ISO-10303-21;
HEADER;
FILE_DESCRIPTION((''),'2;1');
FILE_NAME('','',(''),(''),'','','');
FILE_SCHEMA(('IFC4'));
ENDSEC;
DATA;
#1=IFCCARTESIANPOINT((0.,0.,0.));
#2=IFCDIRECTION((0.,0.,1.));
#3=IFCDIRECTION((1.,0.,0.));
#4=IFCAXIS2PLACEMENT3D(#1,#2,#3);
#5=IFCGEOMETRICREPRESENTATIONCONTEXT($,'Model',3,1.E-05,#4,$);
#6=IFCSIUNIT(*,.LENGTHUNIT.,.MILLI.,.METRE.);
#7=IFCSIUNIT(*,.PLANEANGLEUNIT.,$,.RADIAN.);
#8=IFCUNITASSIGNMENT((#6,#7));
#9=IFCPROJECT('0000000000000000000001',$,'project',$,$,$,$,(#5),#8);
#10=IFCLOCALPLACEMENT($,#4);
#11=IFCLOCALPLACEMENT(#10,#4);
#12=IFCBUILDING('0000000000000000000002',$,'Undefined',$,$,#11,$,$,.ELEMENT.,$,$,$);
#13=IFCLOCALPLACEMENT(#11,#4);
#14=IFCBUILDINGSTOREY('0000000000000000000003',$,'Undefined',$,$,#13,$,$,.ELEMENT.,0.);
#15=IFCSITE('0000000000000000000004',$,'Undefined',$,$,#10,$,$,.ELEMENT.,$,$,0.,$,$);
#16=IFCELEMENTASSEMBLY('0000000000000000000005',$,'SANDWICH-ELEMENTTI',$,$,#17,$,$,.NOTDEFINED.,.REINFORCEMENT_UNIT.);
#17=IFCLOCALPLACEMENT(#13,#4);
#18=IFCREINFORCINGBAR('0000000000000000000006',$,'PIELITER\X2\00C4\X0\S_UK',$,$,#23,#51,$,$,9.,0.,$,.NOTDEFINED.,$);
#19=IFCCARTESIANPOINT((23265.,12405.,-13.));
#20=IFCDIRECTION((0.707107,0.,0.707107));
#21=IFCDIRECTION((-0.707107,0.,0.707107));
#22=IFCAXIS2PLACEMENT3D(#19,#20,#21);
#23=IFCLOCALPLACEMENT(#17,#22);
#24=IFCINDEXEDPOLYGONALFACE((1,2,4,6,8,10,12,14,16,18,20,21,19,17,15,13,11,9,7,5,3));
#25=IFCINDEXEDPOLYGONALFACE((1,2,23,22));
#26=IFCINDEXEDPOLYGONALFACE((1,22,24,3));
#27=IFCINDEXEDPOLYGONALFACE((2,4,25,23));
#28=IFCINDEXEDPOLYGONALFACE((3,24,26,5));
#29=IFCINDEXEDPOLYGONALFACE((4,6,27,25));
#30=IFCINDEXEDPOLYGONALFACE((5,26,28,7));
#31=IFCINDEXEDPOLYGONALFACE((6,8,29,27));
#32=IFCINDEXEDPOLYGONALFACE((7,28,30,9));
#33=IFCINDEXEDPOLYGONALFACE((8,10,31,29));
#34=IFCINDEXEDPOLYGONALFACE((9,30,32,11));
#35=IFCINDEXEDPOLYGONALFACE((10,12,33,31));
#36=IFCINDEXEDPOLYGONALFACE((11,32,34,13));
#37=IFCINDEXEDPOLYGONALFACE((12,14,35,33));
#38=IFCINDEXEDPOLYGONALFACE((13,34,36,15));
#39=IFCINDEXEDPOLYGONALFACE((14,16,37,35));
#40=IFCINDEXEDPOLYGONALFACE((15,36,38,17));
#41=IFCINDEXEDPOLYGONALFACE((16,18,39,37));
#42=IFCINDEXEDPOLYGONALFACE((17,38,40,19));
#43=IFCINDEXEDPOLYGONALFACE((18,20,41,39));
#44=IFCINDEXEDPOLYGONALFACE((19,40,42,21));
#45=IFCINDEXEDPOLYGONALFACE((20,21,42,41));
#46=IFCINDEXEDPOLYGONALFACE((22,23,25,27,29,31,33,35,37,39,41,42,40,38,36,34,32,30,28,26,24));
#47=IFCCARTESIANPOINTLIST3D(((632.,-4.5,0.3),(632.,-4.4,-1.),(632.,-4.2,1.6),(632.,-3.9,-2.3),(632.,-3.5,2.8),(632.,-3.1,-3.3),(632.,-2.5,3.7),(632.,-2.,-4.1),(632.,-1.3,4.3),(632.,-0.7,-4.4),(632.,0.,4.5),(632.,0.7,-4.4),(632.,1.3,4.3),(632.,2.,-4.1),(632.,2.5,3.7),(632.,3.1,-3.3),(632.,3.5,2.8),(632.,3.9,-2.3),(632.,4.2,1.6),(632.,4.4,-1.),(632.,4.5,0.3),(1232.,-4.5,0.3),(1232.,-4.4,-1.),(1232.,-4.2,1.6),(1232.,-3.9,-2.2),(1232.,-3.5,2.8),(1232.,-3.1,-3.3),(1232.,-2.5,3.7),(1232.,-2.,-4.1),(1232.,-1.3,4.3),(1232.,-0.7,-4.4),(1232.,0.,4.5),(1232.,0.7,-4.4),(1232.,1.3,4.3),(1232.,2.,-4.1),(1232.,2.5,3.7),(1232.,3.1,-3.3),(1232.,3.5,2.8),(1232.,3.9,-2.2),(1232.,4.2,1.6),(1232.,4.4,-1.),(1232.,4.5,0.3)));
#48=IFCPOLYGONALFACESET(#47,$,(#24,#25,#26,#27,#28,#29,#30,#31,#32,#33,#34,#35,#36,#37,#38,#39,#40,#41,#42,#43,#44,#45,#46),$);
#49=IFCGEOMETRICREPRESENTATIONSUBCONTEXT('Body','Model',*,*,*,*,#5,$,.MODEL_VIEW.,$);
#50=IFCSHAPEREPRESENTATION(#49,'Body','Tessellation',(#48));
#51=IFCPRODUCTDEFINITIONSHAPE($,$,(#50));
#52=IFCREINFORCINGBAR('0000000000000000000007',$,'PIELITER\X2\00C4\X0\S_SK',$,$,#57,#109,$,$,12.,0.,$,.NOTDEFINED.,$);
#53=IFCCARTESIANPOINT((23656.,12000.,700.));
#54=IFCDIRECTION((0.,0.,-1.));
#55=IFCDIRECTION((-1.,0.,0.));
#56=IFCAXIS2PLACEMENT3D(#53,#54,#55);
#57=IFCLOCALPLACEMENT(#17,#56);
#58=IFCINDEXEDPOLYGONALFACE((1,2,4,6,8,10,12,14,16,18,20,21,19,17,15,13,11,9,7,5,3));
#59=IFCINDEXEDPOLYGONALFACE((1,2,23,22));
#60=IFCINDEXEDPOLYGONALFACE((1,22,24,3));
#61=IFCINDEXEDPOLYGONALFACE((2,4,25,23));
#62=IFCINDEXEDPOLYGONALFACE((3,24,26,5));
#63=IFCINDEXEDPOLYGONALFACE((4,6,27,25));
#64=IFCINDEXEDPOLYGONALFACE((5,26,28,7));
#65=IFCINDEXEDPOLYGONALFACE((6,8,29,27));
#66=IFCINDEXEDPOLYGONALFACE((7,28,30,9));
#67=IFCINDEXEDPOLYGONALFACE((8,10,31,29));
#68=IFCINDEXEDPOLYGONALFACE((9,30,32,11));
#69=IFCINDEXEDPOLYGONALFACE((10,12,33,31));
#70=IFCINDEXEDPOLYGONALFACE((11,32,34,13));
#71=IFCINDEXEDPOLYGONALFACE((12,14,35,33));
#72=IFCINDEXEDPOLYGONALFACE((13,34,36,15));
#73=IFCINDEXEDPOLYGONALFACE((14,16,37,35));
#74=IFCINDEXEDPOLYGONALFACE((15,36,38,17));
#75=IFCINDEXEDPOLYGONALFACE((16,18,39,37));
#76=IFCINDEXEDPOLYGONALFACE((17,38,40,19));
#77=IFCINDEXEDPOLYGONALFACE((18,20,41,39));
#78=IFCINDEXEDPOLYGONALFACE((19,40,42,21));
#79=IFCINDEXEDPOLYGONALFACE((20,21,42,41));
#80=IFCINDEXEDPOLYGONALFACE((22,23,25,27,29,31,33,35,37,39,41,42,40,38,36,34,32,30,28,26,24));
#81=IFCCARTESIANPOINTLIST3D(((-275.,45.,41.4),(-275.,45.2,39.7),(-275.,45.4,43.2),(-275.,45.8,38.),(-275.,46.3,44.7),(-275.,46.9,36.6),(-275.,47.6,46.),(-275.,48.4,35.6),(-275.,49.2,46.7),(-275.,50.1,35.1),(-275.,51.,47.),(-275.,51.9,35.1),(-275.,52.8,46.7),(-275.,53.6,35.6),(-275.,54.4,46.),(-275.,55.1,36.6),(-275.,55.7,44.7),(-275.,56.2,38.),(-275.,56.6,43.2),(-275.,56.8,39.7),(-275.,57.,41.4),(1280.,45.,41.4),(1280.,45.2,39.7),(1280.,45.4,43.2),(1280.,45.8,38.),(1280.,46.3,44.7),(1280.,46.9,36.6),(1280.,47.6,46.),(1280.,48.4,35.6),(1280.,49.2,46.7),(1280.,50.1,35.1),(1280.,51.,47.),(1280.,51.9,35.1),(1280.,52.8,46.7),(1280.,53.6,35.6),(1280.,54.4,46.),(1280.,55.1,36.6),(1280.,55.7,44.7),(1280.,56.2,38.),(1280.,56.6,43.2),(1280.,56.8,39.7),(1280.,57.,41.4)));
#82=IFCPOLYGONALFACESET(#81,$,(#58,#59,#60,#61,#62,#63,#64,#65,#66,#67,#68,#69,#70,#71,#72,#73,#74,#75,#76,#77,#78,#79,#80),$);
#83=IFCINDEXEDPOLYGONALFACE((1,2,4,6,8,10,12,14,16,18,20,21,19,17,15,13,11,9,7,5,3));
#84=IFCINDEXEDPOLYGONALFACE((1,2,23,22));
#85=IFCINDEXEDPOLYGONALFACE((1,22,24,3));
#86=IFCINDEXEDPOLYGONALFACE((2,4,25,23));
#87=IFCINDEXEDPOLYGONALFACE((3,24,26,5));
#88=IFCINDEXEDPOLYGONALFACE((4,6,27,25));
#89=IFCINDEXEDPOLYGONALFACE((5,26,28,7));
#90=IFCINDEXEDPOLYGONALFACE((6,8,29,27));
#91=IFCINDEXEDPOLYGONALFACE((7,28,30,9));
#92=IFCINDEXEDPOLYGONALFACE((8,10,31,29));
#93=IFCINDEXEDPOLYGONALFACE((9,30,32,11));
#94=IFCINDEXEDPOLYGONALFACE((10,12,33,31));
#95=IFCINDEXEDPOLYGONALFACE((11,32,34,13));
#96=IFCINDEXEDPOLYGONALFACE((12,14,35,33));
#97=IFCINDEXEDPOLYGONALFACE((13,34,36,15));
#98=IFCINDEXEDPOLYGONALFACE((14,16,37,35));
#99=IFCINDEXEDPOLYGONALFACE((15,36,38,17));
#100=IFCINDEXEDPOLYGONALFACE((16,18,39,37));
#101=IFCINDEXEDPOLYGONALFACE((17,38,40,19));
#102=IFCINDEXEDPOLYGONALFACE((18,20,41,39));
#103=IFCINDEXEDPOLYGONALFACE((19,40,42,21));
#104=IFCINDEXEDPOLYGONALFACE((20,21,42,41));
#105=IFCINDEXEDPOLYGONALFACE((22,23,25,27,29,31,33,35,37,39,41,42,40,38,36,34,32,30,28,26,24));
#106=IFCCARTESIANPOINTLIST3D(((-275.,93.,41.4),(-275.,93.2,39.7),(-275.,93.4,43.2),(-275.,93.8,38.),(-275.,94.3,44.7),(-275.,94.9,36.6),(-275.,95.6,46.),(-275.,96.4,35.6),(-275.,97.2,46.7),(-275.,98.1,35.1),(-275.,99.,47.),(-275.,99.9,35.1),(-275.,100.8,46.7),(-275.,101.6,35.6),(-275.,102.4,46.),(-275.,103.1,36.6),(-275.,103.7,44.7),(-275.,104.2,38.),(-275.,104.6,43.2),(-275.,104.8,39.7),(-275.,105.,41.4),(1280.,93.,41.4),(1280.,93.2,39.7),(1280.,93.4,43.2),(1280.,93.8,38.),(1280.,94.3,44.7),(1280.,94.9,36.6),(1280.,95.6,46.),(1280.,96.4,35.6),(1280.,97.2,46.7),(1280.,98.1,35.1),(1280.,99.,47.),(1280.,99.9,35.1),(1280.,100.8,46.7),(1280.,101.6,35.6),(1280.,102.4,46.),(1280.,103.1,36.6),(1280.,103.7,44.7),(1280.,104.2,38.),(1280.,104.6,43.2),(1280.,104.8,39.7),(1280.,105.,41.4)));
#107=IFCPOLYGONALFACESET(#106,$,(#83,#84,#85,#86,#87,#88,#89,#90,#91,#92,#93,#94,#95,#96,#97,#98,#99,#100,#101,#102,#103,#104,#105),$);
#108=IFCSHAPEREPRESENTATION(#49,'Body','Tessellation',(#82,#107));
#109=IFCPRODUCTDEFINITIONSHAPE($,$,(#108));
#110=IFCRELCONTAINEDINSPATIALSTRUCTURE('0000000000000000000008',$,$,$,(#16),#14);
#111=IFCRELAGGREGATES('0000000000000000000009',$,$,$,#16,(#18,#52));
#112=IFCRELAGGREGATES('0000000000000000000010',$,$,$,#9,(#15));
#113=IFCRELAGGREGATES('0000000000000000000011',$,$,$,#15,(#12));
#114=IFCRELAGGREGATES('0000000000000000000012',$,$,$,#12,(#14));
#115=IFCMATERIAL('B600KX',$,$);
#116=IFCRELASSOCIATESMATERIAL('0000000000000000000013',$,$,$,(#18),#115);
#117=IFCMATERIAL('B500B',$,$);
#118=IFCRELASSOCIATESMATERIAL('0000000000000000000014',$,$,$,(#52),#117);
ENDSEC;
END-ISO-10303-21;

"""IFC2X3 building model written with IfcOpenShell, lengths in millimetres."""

from ifc_helpers import new_model, entity, si_unit, frame, origin_with_axes, place, context, subcontext, project, spatial, source, transform, mapped, material, element, aggregate, save


model = new_model("IFC2X3")

# Units and contexts
model_context = context("Model", 3, precision=1e-05, world=origin_with_axes())
body_context = subcontext(model_context, "Body", "Model", "MODEL_VIEW")
ifc_project = project(units=[si_unit("LENGTHUNIT", "METRE", prefix="MILLI"), si_unit("PLANEANGLEUNIT", "RADIAN")], contexts=[model_context])

# Site, building, storey
site_placement = place(None, origin_with_axes())
site = spatial("IfcSite", under=ifc_project, at=site_placement, Name="Undefined", CompositionType="ELEMENT", RefElevation=0.0)
building_placement = place(site_placement, origin_with_axes())
building = spatial("IfcBuilding", under=site, at=building_placement, Name="Undefined", CompositionType="ELEMENT")
storey_placement = place(building_placement, origin_with_axes())
storey = spatial("IfcBuildingStorey", under=building, at=storey_placement, Name="Undefined", CompositionType="ELEMENT", Elevation=0.0)

# Element assembly
assembly_1_placement = place(storey_placement, origin_with_axes())
assembly_1 = element("IfcElementAssembly", 1, at=assembly_1_placement, inside=storey, Name="SANDWICH-ELEMENTTI", AssemblyPlace="NOTDEFINED", PredefinedType="REINFORCEMENT_UNIT")

# Reinforcing bars
ifc_material_1 = material(Name="B600KX")
shared_shape_1 = source(origin_with_axes(), body_context, "Body", "AdvancedSweptSolid", [
    entity("IfcSweptDiskSolid", entity("IfcTrimmedCurve", entity("IfcLine", entity("IfcCartesianPoint", [0.0, 0.0, 0.0]), entity("IfcVector", entity("IfcDirection", [1.0, 0.0, 0.0]), 1.0)), [entity("IfcParameterValue", 0.0)], [entity("IfcParameterValue", 600.0)], True, "PARAMETER"), 4.5, None, 0.0, 600.0),
])
reinforcing_bar_1_placement = place(assembly_1_placement, frame((23265.0, 12405.0, -13.0), z_axis=(0.707107, 0.0, 0.707107), x_axis=(-0.707107, 0.0, 0.707107)))
reinforcing_bar_1 = element("IfcReinforcingBar", 2, at=reinforcing_bar_1_placement, material=ifc_material_1, Name="PIELITERÄS_UK", BarRole="NOTDEFINED", CrossSectionArea=0.0, NominalDiameter=9.0, context=body_context, shape_type="MappedRepresentation", body=[
    mapped(shared_shape_1, transform((632.0, 0.0, 0.0))),
])
ifc_material_2 = material(Name="B500B")
shared_shape_2 = source(origin_with_axes(), body_context, "Body", "AdvancedSweptSolid", [
    entity("IfcSweptDiskSolid", entity("IfcTrimmedCurve", entity("IfcLine", entity("IfcCartesianPoint", [0.0, 0.0, 0.0]), entity("IfcVector", entity("IfcDirection", [1.0, 0.0, 0.0]), 1.0)), [entity("IfcParameterValue", 0.0)], [entity("IfcParameterValue", 1555.0)], True, "PARAMETER"), 6.0, None, 0.0, 1555.0),
])
shared_shape_3 = source(origin_with_axes(), body_context, "Body", "AdvancedSweptSolid", [
    entity("IfcSweptDiskSolid", entity("IfcTrimmedCurve", entity("IfcLine", entity("IfcCartesianPoint", [0.0, 0.0, 0.0]), entity("IfcVector", entity("IfcDirection", [1.0, 0.0, 0.0]), 1.0)), [entity("IfcParameterValue", 0.0)], [entity("IfcParameterValue", 1555.0)], True, "PARAMETER"), 6.0, None, 0.0, 1555.0),
])
reinforcing_bar_2_placement = place(assembly_1_placement, frame((23656.0, 12000.0, 700.0), z_axis=(0.0, 0.0, -1.0), x_axis=(-1.0, 0.0, 0.0)))
reinforcing_bar_2 = element("IfcReinforcingBar", 3, at=reinforcing_bar_2_placement, material=ifc_material_2, Name="PIELITERÄS_SK", BarRole="NOTDEFINED", CrossSectionArea=0.0, NominalDiameter=12.0, context=body_context, shape_type="MappedRepresentation", body=[
    mapped(shared_shape_2, transform((-275.0, 51.0, 41.0))),
    mapped(shared_shape_3, transform((-275.0, 99.0, 41.0))),
])
aggregate(assembly_1, [reinforcing_bar_1, reinforcing_bar_2])

save(model, "model.ifc")
